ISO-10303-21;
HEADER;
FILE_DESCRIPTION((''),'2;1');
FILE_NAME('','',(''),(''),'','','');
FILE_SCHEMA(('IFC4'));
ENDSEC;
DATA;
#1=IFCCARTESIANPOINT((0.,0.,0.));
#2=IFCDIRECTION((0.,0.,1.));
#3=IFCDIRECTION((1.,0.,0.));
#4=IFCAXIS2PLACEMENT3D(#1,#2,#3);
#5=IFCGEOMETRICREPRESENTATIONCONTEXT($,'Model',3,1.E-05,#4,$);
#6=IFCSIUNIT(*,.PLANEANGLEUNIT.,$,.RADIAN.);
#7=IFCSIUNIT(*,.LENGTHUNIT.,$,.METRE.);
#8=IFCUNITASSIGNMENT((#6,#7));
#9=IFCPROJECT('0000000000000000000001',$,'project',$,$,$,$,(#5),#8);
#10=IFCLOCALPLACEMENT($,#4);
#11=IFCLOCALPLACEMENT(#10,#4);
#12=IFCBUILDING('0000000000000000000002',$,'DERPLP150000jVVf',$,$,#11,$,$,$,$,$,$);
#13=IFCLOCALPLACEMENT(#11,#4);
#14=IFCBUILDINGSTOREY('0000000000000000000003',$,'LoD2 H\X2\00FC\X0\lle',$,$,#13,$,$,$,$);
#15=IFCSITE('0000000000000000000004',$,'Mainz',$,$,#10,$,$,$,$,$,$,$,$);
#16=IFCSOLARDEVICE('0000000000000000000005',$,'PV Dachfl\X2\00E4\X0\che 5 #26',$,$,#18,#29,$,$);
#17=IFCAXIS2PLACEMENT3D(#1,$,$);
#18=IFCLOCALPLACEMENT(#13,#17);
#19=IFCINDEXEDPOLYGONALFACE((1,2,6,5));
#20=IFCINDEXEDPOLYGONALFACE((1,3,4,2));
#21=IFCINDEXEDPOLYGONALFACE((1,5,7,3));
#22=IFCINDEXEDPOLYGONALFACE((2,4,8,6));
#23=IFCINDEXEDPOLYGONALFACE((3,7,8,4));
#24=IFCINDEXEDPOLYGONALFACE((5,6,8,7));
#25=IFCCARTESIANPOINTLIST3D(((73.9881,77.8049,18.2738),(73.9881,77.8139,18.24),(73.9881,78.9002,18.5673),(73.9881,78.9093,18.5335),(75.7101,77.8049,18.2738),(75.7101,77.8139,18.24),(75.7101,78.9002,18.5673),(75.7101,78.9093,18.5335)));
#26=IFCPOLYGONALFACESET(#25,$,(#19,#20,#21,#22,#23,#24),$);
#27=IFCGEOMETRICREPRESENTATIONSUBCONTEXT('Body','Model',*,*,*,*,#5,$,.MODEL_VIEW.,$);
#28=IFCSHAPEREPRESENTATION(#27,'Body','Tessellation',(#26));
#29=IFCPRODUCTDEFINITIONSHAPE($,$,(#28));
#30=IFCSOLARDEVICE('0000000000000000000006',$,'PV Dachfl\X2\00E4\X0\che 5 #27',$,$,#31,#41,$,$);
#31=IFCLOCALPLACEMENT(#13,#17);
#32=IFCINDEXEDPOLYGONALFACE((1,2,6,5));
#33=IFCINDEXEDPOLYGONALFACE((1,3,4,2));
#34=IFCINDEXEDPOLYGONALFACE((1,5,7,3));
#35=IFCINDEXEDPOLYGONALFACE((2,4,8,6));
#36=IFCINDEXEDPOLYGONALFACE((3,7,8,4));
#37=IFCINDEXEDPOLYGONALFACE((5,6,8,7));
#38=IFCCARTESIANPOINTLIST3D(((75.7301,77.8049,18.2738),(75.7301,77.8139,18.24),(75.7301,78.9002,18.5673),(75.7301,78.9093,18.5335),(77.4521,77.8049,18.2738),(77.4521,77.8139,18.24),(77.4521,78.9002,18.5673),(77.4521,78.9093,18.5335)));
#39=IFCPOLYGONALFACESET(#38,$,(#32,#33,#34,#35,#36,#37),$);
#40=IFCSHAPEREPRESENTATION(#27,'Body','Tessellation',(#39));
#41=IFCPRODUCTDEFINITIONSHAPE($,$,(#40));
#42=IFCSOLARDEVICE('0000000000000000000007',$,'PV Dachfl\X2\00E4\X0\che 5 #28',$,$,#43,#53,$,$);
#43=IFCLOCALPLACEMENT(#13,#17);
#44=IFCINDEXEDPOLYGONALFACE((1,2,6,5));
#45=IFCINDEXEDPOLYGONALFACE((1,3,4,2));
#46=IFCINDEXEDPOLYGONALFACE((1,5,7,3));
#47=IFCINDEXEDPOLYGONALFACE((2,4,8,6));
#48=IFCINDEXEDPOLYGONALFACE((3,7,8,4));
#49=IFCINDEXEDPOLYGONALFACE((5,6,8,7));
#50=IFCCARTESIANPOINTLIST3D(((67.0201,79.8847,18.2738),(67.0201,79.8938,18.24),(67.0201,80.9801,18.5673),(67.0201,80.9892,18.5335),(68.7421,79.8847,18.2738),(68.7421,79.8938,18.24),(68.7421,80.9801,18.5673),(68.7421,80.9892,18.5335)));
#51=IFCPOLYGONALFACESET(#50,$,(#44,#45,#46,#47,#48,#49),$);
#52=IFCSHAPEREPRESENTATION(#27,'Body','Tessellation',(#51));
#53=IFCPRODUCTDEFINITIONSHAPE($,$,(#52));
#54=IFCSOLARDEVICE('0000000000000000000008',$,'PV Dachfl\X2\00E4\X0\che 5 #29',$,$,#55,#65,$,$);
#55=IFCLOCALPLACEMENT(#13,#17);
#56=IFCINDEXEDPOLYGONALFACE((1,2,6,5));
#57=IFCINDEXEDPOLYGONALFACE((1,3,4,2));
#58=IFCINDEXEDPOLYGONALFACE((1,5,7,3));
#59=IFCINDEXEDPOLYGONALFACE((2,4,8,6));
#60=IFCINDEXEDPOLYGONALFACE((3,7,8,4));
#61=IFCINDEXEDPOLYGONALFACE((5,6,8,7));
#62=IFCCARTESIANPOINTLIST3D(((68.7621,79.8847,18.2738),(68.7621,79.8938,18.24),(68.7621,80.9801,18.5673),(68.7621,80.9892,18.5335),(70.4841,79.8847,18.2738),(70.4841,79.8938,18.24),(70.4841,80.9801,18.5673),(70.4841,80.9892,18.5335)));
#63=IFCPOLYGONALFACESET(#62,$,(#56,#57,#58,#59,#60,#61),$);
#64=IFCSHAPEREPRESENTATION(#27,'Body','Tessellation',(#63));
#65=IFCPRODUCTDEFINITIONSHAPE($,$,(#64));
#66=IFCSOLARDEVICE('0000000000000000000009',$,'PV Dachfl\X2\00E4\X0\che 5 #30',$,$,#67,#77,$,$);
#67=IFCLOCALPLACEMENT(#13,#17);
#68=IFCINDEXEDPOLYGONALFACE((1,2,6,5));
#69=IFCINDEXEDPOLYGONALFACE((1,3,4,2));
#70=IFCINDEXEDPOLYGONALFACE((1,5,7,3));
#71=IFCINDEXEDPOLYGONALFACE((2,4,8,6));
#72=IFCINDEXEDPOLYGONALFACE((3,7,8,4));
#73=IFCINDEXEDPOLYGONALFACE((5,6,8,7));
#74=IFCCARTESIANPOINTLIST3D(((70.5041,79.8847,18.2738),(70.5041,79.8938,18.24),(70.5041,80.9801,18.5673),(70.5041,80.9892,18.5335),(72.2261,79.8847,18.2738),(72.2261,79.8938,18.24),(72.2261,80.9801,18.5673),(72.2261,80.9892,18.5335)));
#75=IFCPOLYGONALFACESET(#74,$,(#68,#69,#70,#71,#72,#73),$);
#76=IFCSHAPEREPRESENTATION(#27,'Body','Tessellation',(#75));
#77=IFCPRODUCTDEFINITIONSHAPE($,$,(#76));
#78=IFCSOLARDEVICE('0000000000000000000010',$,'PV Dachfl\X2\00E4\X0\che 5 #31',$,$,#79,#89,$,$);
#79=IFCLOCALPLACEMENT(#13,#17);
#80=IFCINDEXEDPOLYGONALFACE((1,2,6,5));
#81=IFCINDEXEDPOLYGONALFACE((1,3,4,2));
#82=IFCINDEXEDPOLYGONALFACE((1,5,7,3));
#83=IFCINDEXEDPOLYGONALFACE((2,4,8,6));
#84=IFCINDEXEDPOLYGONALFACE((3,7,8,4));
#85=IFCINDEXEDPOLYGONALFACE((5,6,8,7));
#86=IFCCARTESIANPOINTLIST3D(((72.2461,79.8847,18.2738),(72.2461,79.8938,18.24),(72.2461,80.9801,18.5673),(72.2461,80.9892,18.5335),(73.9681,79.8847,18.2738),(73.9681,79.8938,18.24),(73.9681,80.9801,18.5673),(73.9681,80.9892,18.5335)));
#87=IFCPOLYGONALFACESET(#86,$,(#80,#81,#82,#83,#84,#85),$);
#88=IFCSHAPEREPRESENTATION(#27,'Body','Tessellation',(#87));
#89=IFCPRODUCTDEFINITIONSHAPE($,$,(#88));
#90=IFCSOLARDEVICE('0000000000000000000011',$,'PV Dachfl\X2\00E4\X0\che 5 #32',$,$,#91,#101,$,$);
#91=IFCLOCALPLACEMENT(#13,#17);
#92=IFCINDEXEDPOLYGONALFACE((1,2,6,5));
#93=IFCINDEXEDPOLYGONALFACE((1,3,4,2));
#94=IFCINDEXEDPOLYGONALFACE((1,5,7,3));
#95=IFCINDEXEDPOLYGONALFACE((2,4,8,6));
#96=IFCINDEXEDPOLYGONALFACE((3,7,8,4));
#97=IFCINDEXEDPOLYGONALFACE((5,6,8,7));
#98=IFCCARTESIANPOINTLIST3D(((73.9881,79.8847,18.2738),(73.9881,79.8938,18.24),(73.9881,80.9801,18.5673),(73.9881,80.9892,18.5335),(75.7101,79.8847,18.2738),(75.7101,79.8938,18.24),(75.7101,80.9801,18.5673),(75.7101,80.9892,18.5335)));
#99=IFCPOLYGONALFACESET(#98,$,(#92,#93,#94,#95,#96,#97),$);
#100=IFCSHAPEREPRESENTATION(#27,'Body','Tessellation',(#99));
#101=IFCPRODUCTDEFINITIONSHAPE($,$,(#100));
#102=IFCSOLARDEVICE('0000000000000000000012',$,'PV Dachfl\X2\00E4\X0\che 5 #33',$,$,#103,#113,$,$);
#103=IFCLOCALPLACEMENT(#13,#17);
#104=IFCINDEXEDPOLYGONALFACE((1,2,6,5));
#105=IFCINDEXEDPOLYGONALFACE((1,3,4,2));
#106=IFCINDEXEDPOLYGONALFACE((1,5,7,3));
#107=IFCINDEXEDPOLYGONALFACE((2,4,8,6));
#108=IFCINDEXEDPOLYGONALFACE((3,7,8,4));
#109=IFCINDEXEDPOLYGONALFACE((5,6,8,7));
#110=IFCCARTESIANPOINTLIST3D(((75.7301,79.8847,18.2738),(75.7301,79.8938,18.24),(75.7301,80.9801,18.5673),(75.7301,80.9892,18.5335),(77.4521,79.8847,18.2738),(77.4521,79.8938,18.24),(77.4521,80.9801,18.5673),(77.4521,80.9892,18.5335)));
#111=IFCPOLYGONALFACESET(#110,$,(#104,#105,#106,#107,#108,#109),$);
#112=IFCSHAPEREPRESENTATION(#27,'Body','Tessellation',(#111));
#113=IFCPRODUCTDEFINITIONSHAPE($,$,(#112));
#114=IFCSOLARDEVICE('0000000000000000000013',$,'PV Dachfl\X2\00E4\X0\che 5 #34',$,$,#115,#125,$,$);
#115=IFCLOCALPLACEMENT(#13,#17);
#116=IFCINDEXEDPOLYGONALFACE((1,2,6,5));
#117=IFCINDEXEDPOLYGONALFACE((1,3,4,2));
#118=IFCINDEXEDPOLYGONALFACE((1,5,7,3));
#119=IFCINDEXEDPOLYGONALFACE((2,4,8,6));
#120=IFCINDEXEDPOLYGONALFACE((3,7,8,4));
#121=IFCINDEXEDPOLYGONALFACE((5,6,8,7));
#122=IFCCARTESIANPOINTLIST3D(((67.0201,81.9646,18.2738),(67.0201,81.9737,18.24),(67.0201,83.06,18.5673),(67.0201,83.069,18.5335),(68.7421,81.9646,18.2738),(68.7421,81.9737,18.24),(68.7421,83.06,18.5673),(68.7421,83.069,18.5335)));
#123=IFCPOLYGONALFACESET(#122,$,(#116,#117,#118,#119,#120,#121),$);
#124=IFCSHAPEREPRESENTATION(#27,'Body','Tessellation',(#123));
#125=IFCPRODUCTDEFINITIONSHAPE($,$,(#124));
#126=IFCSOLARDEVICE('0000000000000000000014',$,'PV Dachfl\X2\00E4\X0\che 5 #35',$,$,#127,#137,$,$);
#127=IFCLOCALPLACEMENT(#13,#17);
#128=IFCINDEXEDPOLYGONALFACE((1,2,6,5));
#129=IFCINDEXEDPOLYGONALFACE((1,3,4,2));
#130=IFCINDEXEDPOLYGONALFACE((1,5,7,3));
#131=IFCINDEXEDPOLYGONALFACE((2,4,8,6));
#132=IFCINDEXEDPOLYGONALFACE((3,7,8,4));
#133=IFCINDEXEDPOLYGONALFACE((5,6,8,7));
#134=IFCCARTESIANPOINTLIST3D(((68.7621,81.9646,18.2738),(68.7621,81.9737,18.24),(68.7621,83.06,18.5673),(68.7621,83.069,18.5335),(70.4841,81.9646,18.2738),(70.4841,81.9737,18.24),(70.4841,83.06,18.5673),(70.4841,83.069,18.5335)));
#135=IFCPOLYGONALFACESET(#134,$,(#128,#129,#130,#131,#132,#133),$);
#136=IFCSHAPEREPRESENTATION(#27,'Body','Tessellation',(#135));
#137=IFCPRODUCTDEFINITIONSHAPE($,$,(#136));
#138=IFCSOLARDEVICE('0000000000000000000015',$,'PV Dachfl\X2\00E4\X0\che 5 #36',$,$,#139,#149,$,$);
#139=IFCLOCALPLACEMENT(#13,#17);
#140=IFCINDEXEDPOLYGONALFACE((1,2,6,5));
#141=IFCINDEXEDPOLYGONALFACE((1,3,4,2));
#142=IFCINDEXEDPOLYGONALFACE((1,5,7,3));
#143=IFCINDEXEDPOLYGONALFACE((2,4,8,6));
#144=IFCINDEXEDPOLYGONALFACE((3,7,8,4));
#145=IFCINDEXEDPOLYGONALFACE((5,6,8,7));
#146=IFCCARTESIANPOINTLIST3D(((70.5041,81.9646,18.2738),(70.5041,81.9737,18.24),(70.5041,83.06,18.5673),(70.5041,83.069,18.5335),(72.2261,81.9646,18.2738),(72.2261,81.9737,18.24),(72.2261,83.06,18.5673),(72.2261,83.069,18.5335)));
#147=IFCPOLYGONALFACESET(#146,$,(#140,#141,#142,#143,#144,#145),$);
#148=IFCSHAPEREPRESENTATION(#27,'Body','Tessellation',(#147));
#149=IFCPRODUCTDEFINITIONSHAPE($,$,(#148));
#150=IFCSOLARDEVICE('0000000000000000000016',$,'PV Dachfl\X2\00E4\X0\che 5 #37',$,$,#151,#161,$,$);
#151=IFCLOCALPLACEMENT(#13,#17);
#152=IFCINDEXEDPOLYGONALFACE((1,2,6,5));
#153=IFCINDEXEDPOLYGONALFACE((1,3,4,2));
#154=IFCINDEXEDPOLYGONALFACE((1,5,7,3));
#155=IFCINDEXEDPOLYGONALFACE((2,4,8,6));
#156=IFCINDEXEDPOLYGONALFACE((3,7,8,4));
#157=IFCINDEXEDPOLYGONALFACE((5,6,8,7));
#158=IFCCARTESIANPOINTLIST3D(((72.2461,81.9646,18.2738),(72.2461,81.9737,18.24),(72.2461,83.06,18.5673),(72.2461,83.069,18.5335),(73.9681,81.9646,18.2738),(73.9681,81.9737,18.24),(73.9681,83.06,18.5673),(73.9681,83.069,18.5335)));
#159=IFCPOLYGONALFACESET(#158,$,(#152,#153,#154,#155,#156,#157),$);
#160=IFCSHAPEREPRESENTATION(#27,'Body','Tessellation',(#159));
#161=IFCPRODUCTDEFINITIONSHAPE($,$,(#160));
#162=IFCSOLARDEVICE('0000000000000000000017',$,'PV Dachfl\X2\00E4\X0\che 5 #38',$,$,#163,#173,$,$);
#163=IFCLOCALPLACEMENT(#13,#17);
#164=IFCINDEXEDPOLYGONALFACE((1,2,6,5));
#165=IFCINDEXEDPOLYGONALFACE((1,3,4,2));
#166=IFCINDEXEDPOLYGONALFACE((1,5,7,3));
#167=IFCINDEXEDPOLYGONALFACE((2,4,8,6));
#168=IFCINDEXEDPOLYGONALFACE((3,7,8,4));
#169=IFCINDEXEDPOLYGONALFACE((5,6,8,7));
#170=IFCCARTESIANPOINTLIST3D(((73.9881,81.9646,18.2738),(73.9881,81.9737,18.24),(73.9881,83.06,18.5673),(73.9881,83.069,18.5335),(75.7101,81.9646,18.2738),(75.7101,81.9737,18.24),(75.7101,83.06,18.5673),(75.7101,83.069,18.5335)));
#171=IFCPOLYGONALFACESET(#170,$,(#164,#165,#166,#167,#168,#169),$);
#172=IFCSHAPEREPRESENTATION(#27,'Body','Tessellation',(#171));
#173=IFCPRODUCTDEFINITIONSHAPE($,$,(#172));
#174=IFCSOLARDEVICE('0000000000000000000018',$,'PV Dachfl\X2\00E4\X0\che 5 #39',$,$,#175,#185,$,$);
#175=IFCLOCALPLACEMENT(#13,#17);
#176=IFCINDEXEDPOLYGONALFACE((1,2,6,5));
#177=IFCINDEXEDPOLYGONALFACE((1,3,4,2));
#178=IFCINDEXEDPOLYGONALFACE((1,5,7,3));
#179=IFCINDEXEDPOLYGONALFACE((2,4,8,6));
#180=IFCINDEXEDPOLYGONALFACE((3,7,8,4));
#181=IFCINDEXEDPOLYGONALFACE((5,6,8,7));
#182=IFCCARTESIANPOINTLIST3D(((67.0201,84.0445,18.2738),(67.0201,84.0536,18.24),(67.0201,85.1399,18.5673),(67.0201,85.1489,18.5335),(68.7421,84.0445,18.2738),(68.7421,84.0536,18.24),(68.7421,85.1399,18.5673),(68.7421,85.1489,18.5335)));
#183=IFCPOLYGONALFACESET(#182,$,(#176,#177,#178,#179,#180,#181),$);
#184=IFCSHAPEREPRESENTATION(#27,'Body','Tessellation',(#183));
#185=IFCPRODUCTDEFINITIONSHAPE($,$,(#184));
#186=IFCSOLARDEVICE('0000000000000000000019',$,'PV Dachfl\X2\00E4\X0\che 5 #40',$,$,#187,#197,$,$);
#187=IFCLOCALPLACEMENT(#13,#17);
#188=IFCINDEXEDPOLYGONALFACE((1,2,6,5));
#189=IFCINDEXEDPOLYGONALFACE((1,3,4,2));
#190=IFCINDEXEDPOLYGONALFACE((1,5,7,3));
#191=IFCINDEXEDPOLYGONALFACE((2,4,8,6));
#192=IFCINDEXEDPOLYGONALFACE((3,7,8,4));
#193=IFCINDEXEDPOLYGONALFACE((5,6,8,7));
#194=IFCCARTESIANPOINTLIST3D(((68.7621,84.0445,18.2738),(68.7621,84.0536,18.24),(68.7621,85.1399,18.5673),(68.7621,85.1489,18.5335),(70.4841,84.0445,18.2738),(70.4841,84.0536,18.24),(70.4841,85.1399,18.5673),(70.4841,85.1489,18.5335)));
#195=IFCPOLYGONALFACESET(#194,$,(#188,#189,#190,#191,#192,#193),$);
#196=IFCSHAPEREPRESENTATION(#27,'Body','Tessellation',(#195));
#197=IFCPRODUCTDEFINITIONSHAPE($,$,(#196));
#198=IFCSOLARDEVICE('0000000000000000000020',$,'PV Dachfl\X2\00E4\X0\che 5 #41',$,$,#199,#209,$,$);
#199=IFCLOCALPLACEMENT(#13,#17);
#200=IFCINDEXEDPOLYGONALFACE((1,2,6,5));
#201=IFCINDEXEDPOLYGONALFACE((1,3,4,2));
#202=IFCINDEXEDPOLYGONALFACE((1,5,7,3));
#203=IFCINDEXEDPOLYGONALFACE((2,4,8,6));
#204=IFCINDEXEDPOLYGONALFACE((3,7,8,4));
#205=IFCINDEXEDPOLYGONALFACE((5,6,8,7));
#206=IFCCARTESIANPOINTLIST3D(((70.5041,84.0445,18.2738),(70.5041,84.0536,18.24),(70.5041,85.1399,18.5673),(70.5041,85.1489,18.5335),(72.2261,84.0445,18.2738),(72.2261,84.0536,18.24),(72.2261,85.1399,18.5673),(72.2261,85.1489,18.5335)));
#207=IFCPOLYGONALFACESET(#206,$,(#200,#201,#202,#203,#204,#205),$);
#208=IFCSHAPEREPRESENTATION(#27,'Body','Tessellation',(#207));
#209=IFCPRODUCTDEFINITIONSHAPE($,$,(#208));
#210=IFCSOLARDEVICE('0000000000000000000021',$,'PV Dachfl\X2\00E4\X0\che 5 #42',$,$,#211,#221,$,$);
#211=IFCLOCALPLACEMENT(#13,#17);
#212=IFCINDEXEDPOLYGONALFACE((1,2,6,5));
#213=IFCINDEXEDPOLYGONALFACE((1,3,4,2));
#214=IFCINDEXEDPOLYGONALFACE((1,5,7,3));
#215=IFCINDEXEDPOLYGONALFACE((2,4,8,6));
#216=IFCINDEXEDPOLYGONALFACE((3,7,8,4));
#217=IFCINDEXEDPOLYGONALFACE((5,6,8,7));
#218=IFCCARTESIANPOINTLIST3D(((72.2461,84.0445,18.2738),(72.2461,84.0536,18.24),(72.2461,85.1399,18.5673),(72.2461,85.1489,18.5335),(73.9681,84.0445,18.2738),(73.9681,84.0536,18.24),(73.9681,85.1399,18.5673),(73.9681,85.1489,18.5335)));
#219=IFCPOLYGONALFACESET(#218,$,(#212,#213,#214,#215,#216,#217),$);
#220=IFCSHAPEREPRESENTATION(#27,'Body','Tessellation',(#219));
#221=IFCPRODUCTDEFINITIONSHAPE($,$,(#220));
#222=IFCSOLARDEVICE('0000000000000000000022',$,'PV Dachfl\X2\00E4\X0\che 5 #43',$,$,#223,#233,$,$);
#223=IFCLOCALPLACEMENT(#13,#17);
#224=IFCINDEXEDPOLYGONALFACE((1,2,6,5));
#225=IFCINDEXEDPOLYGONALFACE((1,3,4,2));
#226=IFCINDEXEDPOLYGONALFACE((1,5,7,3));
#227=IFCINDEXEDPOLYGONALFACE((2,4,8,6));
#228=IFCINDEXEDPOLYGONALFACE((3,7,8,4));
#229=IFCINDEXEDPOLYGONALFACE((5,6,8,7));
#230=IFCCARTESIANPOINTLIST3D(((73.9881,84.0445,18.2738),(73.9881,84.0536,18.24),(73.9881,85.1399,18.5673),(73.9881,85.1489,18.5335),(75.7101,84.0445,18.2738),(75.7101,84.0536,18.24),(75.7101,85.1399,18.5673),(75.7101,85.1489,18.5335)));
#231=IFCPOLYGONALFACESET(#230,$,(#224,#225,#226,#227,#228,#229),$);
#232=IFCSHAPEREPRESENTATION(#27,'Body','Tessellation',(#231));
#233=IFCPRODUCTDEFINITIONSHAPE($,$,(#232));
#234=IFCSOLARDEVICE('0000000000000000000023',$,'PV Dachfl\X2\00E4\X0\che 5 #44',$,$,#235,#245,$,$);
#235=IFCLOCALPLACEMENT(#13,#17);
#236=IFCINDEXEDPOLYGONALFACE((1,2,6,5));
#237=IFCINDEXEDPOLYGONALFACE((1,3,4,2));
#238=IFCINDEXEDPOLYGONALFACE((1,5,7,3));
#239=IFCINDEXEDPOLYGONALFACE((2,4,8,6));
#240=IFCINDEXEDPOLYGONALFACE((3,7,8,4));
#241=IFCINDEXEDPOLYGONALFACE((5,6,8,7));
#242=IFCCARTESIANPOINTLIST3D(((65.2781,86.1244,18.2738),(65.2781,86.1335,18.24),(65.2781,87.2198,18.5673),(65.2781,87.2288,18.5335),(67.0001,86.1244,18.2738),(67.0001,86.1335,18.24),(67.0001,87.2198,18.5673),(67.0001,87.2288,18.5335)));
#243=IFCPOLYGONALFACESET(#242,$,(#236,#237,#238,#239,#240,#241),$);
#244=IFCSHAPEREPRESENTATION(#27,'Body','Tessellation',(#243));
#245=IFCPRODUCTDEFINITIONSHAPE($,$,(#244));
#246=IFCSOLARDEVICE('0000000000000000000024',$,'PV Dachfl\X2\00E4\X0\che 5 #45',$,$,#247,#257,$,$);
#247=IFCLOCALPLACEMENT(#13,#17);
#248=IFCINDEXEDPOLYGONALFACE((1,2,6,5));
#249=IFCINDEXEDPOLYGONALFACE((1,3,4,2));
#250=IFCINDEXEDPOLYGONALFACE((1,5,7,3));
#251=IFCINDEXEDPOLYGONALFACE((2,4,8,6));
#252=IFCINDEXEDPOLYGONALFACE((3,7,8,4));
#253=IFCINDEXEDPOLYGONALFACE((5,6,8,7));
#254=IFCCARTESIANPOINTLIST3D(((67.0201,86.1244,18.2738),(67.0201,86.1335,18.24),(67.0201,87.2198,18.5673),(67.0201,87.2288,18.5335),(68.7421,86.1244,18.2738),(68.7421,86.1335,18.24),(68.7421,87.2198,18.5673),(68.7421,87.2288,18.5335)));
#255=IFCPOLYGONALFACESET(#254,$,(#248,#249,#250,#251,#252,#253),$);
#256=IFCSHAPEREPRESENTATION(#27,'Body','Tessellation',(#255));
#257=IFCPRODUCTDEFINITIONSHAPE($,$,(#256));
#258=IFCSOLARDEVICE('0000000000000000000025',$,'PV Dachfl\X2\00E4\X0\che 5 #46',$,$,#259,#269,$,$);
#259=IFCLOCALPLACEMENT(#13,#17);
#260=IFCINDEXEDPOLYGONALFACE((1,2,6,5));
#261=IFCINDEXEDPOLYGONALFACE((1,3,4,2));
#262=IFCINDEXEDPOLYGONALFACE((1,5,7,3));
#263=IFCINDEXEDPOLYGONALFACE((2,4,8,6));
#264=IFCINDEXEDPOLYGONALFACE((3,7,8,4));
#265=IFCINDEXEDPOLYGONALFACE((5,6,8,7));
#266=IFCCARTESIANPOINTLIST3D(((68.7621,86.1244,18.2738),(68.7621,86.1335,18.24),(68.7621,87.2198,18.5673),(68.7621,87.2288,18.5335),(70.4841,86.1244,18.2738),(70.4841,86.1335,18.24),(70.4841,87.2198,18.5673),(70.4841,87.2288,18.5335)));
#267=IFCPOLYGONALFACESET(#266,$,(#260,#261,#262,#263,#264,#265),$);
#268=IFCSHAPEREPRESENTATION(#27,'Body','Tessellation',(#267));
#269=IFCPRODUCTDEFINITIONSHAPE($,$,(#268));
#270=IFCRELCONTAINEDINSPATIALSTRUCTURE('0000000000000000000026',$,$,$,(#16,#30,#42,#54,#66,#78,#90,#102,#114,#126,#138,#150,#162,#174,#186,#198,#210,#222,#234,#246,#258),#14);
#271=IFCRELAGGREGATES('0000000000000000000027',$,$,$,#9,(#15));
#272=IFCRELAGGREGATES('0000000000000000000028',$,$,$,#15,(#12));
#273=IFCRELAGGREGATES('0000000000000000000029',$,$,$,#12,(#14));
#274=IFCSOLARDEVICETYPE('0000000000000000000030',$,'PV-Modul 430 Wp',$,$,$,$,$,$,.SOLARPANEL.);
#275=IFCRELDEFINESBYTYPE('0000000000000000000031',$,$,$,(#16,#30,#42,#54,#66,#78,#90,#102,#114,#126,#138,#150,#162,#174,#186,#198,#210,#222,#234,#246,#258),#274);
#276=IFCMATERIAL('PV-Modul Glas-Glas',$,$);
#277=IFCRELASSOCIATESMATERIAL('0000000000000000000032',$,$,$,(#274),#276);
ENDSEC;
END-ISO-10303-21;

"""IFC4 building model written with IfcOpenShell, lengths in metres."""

from ifc_helpers import new_model, si_unit, frame, frame_2d, origin, origin_with_axes, place, context, subcontext, project, spatial, rectangle, extrude, source, transform, mapped, material, type_object, type_shapes, element, save


model = new_model("IFC4")

# Units and contexts
model_context = context("Model", 3, precision=1e-05, world=origin_with_axes())
body_context = subcontext(model_context, "Body", "Model", "MODEL_VIEW")
ifc_project = project(units=[si_unit("PLANEANGLEUNIT", "RADIAN"), si_unit("LENGTHUNIT", "METRE")], contexts=[model_context])

# Site, building, storey
site_placement = place(None, origin_with_axes())
site = spatial("IfcSite", under=ifc_project, at=site_placement, Name="Mainz")
building_placement = place(site_placement, origin_with_axes())
building = spatial("IfcBuilding", under=site, at=building_placement, Name="DERPLP150000jVVf")
storey_placement = place(building_placement, origin_with_axes())
storey = spatial("IfcBuildingStorey", under=building, at=storey_placement, Name="LoD2 Hülle")

# Solar devices
ifc_material = material(Name="PV-Modul Glas-Glas")
solar_device_type = type_object("IfcSolarDeviceType", Name="PV-Modul 430 Wp", PredefinedType="SOLARPANEL", material=ifc_material)
shared_shape = source(origin_with_axes(), body_context, "Body", "SweptSolid", [
    extrude(rectangle(XDim=1.722, YDim=1.134, at=frame_2d((0.861, 0.567))), origin(), (0.0, 0.0, 1.0), 0.035),
])
type_shapes(solar_device_type, [shared_shape])
for number, where, z_axis, x_axis, name in (
    (1, (73.9881, 77.8139, 18.24), (0.0, -0.258819, 0.965926), (1.0, 0.0, 0.0), "PV Dachfläche 5 #26"),
    (2, (75.7301, 77.8139, 18.24), (0.0, -0.258819, 0.965926), (1.0, 0.0, 0.0), "PV Dachfläche 5 #27"),
    (3, (67.0201, 79.8938, 18.24), (0.0, -0.258819, 0.965926), (1.0, 0.0, 0.0), "PV Dachfläche 5 #28"),
    (4, (68.7621, 79.8938, 18.24), (0.0, -0.258819, 0.965926), (1.0, 0.0, 0.0), "PV Dachfläche 5 #29"),
    (5, (70.5041, 79.8938, 18.24), (0.0, -0.258819, 0.965926), (1.0, 0.0, 0.0), "PV Dachfläche 5 #30"),
    (6, (72.2461, 79.8938, 18.24), (0.0, -0.258819, 0.965926), (1.0, 0.0, 0.0), "PV Dachfläche 5 #31"),
    (7, (73.9881, 79.8938, 18.24), (0.0, -0.258819, 0.965926), (1.0, 0.0, 0.0), "PV Dachfläche 5 #32"),
    (8, (75.7301, 79.8938, 18.24), (0.0, -0.258819, 0.965926), (1.0, 0.0, 0.0), "PV Dachfläche 5 #33"),
    (9, (67.0201, 81.9737, 18.24), (0.0, -0.258819, 0.965926), (1.0, 0.0, 0.0), "PV Dachfläche 5 #34"),
    (10, (68.7621, 81.9737, 18.24), (0.0, -0.258819, 0.965926), (1.0, 0.0, 0.0), "PV Dachfläche 5 #35"),
    (11, (70.5041, 81.9737, 18.24), (0.0, -0.258819, 0.965926), (1.0, 0.0, 0.0), "PV Dachfläche 5 #36"),
    (12, (72.2461, 81.9737, 18.24), (0.0, -0.258819, 0.965926), (1.0, 0.0, 0.0), "PV Dachfläche 5 #37"),
    (13, (73.9881, 81.9737, 18.24), (0.0, -0.258819, 0.965926), (1.0, 0.0, 0.0), "PV Dachfläche 5 #38"),
    (14, (67.0201, 84.0536, 18.24), (0.0, -0.258819, 0.965926), (1.0, 0.0, 0.0), "PV Dachfläche 5 #39"),
    (15, (68.7621, 84.0536, 18.24), (0.0, -0.258819, 0.965926), (1.0, 0.0, 0.0), "PV Dachfläche 5 #40"),
    (16, (70.5041, 84.0536, 18.24), (0.0, -0.258819, 0.965926), (1.0, 0.0, 0.0), "PV Dachfläche 5 #41"),
    (17, (72.2461, 84.0536, 18.24), (0.0, -0.258819, 0.965926), (1.0, 0.0, 0.0), "PV Dachfläche 5 #42"),
    (18, (73.9881, 84.0536, 18.24), (0.0, -0.258819, 0.965926), (1.0, 0.0, 0.0), "PV Dachfläche 5 #43"),
    (19, (65.2781, 86.1335, 18.24), (0.0, -0.258819, 0.965926), (1.0, 0.0, 0.0), "PV Dachfläche 5 #44"),
    (20, (67.0201, 86.1335, 18.24), (0.0, -0.258819, 0.965926), (1.0, 0.0, 0.0), "PV Dachfläche 5 #45"),
    (21, (68.7621, 86.1335, 18.24), (0.0, -0.258819, 0.965926), (1.0, 0.0, 0.0), "PV Dachfläche 5 #46"),
):
    element("IfcSolarDevice", number, at=place(storey_placement, frame(where, z_axis=z_axis, x_axis=x_axis)), inside=storey, type_object=solar_device_type, Name=name, context=body_context, shape_type="MappedRepresentation", body=[
        mapped(shared_shape, transform((0.0, 0.0, 0.0), x_axis=(1.0, 0.0, 0.0), y_axis=(0.0, 1.0, 0.0), z_axis=(0.0, 0.0, 1.0), scale=1.0)),
    ])

save(model, "model.ifc")
